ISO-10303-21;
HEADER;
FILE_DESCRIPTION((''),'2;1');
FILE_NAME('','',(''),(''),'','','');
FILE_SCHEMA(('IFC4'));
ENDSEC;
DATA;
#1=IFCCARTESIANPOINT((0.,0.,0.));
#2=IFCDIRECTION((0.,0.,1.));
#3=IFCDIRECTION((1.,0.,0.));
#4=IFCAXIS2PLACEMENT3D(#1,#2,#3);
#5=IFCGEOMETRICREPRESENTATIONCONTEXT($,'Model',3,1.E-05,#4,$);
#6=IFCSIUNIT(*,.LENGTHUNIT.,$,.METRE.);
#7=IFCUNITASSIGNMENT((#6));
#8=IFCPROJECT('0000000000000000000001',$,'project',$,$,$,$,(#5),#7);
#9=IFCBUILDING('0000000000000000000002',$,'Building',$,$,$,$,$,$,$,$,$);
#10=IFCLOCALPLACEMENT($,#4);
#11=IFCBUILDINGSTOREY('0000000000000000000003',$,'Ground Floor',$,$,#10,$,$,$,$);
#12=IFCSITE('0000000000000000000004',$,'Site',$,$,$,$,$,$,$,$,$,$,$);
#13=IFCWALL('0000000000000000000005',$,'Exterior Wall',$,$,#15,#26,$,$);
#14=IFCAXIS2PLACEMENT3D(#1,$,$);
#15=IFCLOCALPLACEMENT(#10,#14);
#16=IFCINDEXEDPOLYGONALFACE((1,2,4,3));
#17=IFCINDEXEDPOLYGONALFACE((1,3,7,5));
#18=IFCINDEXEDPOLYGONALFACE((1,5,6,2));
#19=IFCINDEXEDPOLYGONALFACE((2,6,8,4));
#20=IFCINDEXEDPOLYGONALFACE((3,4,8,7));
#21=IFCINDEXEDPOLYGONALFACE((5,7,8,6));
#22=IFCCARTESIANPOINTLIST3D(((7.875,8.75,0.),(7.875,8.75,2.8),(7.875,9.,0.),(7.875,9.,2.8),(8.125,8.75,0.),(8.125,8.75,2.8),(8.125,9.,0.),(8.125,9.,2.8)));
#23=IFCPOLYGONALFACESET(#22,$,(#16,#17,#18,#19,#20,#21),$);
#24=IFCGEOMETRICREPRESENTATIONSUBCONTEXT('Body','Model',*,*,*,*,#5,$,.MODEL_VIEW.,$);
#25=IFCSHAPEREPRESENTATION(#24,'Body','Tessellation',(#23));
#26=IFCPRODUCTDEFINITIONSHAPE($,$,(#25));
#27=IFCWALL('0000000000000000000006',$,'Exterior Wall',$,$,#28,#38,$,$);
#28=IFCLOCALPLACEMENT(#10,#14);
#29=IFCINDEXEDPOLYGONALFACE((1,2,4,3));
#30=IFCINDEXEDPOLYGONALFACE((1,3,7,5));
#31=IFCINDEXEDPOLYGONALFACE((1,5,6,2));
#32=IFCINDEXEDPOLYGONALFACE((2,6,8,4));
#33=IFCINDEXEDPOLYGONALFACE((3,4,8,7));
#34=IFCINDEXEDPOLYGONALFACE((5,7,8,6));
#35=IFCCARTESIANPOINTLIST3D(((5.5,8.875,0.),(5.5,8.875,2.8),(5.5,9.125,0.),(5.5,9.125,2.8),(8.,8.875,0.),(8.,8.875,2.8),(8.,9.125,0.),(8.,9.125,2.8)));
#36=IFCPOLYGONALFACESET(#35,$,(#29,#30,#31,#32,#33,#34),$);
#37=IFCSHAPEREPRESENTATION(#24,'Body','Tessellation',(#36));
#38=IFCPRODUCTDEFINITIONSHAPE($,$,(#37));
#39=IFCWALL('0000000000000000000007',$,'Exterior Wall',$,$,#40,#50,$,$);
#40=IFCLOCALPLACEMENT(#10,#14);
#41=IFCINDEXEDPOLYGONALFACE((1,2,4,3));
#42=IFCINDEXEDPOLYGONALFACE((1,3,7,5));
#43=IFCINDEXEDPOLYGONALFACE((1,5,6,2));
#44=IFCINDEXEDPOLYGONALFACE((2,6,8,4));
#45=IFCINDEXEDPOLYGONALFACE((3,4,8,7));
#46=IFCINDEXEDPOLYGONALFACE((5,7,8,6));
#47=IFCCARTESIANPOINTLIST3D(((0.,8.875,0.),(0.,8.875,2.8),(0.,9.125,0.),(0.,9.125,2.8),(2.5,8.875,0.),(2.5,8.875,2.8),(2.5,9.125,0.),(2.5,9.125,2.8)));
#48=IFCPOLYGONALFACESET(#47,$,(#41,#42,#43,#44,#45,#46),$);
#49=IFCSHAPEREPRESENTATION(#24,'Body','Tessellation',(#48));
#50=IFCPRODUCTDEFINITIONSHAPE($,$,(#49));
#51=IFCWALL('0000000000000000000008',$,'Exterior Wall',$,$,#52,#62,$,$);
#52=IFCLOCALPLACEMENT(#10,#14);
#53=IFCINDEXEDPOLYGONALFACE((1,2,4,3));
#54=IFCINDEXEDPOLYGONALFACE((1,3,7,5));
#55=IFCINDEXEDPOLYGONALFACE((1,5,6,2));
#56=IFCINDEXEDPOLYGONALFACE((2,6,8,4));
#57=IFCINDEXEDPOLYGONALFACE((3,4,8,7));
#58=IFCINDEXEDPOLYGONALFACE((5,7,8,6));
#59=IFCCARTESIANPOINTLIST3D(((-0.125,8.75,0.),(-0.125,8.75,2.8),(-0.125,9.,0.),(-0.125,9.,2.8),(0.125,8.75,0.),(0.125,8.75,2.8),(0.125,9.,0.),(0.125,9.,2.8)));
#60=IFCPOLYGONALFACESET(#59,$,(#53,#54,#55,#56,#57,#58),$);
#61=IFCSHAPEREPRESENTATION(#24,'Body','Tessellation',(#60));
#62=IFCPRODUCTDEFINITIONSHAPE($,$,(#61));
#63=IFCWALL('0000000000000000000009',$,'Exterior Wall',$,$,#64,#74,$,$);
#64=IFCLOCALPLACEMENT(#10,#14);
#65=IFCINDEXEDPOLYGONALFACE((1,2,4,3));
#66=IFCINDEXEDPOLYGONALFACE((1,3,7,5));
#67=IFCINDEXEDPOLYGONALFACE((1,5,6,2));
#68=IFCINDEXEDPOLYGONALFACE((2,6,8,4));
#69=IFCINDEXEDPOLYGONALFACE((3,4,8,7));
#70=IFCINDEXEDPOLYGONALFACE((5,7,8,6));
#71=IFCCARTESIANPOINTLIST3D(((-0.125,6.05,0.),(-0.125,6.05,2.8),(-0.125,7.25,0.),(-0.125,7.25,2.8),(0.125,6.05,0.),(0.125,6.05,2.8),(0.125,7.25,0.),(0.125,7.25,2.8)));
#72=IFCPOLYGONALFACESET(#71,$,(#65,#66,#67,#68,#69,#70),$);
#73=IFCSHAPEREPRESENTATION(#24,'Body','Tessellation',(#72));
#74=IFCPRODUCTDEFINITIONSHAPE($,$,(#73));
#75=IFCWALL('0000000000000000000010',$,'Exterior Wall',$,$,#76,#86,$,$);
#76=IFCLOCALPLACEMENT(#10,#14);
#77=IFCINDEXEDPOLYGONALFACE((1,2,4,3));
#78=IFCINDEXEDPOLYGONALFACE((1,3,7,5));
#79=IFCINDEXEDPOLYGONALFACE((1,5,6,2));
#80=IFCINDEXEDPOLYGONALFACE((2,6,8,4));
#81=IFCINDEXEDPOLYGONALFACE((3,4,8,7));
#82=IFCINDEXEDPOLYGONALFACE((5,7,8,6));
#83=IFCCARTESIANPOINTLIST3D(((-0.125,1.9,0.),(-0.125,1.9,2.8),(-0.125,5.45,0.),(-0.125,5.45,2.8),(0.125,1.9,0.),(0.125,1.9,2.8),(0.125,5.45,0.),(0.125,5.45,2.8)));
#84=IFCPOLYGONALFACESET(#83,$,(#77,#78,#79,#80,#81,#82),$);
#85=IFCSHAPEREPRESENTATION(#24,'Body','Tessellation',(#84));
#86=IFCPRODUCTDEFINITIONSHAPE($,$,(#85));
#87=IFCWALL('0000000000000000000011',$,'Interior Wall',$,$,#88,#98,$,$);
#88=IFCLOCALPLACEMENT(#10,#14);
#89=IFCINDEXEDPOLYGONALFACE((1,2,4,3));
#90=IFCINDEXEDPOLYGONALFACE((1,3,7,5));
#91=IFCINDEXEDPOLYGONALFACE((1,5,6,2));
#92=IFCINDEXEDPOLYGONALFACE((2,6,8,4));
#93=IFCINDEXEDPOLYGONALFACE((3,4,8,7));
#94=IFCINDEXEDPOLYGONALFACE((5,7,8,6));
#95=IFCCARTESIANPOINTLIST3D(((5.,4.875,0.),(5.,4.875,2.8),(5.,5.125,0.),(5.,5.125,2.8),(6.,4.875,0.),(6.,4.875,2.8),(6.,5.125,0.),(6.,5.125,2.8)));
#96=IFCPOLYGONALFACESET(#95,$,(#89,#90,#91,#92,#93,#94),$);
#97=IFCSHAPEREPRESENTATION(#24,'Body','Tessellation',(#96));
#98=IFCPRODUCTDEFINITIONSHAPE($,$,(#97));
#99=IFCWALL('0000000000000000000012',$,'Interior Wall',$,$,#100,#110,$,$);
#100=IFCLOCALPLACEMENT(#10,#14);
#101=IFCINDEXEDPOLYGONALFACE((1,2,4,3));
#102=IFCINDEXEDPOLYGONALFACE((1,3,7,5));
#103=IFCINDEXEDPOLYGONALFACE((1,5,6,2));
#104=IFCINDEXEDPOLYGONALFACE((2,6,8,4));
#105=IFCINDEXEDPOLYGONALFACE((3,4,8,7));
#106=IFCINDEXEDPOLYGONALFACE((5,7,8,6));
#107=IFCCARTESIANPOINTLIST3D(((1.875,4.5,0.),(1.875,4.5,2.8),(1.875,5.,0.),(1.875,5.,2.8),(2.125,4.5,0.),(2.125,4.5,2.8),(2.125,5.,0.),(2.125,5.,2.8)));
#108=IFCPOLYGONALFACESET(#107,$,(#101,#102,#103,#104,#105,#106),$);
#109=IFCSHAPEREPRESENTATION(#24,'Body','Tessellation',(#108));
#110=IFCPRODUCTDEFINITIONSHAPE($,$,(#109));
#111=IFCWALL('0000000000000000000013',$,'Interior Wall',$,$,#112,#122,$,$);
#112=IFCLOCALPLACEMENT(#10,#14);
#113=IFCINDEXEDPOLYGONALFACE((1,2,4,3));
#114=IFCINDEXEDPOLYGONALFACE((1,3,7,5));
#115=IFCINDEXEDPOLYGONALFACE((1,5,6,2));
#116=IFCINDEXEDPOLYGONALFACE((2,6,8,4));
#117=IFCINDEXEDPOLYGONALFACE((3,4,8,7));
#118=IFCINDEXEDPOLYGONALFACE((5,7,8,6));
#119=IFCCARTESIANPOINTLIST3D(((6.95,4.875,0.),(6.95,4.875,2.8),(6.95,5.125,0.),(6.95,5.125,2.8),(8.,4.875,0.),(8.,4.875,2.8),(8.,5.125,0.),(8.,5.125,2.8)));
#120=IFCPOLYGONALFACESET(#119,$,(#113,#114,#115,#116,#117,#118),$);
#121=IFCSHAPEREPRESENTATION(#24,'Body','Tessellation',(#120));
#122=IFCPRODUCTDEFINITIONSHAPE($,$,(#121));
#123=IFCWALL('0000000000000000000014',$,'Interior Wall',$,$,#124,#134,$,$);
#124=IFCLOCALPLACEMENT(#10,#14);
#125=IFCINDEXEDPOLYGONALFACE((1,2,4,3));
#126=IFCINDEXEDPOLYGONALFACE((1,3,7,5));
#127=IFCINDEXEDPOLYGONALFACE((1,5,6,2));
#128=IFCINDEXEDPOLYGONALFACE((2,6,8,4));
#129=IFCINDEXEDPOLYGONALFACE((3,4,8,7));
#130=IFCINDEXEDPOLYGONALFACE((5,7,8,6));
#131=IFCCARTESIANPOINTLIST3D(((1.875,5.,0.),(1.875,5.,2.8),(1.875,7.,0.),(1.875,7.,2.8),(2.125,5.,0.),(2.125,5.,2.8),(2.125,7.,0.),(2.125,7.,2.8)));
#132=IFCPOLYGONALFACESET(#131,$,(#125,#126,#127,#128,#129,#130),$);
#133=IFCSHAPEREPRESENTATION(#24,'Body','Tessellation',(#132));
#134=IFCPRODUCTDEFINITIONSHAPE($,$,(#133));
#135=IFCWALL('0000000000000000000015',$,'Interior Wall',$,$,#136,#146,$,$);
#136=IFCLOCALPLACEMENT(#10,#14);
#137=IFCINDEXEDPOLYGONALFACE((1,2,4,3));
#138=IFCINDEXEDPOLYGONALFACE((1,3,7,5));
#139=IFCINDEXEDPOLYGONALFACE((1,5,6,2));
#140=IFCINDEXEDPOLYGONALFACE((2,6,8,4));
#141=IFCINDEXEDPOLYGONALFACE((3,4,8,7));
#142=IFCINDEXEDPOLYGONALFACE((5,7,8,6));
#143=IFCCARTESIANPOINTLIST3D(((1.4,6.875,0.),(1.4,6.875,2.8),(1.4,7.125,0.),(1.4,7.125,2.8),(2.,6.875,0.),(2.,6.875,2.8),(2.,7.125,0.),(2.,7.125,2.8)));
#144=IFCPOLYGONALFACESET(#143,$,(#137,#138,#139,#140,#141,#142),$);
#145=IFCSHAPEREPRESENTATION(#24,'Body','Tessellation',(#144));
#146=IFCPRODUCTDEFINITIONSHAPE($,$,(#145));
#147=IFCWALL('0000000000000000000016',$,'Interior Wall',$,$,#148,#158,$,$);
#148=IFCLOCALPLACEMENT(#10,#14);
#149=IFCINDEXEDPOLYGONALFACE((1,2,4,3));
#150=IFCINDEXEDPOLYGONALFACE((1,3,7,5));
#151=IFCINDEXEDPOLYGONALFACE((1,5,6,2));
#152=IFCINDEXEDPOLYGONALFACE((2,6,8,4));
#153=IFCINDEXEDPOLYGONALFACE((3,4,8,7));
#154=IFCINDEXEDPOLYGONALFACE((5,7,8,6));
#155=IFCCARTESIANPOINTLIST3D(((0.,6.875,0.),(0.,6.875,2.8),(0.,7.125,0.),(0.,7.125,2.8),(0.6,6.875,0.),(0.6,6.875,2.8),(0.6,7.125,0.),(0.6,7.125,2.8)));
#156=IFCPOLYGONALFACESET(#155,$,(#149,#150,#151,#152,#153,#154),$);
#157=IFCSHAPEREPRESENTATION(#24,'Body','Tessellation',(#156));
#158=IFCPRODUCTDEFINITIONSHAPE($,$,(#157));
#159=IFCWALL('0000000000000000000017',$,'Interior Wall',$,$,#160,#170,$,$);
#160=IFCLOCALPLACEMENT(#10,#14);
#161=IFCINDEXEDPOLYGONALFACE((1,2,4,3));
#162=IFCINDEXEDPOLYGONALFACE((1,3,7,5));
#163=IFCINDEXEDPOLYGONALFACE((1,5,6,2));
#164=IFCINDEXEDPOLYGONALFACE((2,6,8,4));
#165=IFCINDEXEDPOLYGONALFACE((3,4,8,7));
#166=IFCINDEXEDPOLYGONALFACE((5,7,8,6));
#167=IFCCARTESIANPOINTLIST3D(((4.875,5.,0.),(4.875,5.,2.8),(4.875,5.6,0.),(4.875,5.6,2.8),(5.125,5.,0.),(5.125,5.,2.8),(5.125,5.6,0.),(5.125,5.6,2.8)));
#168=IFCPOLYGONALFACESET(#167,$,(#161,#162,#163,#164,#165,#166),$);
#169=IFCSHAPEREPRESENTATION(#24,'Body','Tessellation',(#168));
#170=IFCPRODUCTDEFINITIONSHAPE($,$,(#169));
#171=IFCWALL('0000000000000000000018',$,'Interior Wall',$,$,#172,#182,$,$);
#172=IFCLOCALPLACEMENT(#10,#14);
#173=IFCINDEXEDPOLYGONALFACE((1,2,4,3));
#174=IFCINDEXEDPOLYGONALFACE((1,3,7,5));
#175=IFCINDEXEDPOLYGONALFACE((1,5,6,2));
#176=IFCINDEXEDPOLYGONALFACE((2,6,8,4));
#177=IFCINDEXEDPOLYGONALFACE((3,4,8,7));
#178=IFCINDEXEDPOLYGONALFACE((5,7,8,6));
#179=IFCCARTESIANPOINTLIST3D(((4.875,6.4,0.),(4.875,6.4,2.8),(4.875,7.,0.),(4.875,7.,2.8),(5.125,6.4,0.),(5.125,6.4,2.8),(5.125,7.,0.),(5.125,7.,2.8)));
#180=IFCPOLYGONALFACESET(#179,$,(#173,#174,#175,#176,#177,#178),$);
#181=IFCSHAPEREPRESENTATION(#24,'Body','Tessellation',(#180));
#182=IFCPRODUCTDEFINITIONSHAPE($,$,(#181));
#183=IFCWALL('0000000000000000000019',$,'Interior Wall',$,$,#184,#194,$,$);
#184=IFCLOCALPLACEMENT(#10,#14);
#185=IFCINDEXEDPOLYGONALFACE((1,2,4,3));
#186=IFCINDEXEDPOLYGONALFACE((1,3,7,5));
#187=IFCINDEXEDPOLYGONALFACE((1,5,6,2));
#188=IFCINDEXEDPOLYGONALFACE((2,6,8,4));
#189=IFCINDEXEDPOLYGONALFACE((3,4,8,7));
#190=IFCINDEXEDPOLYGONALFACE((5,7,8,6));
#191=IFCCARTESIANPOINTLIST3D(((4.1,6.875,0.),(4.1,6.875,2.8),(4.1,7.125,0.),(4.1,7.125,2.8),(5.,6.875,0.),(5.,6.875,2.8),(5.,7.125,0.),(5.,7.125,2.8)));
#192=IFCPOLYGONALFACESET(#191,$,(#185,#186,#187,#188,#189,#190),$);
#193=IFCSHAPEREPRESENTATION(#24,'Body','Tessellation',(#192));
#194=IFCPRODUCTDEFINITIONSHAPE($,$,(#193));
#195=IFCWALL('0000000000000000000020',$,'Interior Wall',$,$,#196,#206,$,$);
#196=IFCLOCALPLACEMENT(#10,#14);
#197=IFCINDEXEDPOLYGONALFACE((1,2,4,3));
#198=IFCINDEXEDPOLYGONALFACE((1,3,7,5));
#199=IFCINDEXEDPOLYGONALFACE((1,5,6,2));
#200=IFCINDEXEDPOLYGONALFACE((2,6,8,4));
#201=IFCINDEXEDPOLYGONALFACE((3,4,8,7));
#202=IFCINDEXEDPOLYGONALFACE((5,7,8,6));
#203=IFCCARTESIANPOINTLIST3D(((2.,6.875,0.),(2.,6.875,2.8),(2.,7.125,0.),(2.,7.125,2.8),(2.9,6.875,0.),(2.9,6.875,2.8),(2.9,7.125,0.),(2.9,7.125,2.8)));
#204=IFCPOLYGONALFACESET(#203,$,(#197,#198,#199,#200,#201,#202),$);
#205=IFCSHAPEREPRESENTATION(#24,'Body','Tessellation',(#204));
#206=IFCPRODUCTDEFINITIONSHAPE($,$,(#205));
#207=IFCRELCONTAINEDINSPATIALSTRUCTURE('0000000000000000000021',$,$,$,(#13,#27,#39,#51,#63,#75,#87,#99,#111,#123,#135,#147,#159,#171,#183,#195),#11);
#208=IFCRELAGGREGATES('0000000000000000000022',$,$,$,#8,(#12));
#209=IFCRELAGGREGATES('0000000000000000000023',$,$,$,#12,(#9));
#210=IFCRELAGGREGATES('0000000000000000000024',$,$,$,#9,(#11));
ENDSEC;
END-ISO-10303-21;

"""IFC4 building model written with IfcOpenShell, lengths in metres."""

from ifc_helpers import new_model, si_unit, frame, origin_with_axes, place, context, subcontext, project, spatial, indexed_curve, outline, extrude, element, save


model = new_model("IFC4")

# Units and contexts
model_context = context("Model", 3, precision=1e-05, world=origin_with_axes())
body_context = subcontext(model_context, "Body", "Model", "MODEL_VIEW")
ifc_project = project(units=[si_unit("LENGTHUNIT", "METRE")], contexts=[model_context])

# Site, building, storey
site = spatial("IfcSite", under=ifc_project, Name="Site")
building = spatial("IfcBuilding", under=site, Name="Building")
storey_placement = place(None, origin_with_axes())
storey = spatial("IfcBuildingStorey", under=building, at=storey_placement, Name="Ground Floor")

# Walls
wall_1_placement = place(storey_placement, frame((8.0, 8.75, 0.0), z_axis=(0.0, 0.0, 1.0), x_axis=(0.0, 1.0, 0.0)))
element("IfcWall", 1, at=wall_1_placement, inside=storey, Name="Exterior Wall", context=body_context, shape_type="SweptSolid", body=[
    extrude(outline(indexed_curve([(0.0, 0.0), (0.0, 0.25), (0.25, 0.25), (0.25, 0.0), (0.0, 0.0)], self_intersect=False)), frame((0.0, -0.125, 0.0), z_axis=(0.0, 0.0, 1.0), x_axis=(1.0, 0.0, 0.0)), (0.0, 0.0, 1.0), 2.8),
])
for number, where, z_axis, x_axis, name in (
    (2, (8.0, 9.0, 0.0), (0.0, 0.0, 1.0), (-1.0, 0.0, 0.0), "Exterior Wall"),
    (3, (2.5, 9.0, 0.0), (0.0, 0.0, 1.0), (-1.0, 0.0, 0.0), "Exterior Wall"),
):
    element("IfcWall", number, at=place(storey_placement, frame(where, z_axis=z_axis, x_axis=x_axis)), inside=storey, Name=name, context=body_context, shape_type="SweptSolid", body=[
        extrude(outline(indexed_curve([(0.0, 0.0), (0.0, 0.25), (2.5, 0.25), (2.5, 0.0), (0.0, 0.0)], self_intersect=False)), frame((0.0, -0.125, 0.0), z_axis=(0.0, 0.0, 1.0), x_axis=(1.0, 0.0, 0.0)), (0.0, 0.0, 1.0), 2.8),
    ])
wall_2_placement = place(storey_placement, frame((0.0, 9.0, 0.0), z_axis=(0.0, 0.0, 1.0), x_axis=(0.0, -1.0, 0.0)))
element("IfcWall", 4, at=wall_2_placement, inside=storey, Name="Exterior Wall", context=body_context, shape_type="SweptSolid", body=[
    extrude(outline(indexed_curve([(0.0, 0.0), (0.0, 0.25), (0.25, 0.25), (0.25, 0.0), (0.0, 0.0)], self_intersect=False)), frame((0.0, -0.125, 0.0), z_axis=(0.0, 0.0, 1.0), x_axis=(1.0, 0.0, 0.0)), (0.0, 0.0, 1.0), 2.8),
])
wall_3_placement = place(storey_placement, frame((0.0, 7.25, 0.0), z_axis=(0.0, 0.0, 1.0), x_axis=(0.0, -1.0, 0.0)))
element("IfcWall", 5, at=wall_3_placement, inside=storey, Name="Exterior Wall", context=body_context, shape_type="SweptSolid", body=[
    extrude(outline(indexed_curve([(0.0, 0.0), (0.0, 0.25), (1.2, 0.25), (1.2, 0.0), (0.0, 0.0)], self_intersect=False)), frame((0.0, -0.125, 0.0), z_axis=(0.0, 0.0, 1.0), x_axis=(1.0, 0.0, 0.0)), (0.0, 0.0, 1.0), 2.8),
])
wall_4_placement = place(storey_placement, frame((0.0, 5.45, 0.0), z_axis=(0.0, 0.0, 1.0), x_axis=(0.0, -1.0, 0.0)))
element("IfcWall", 6, at=wall_4_placement, inside=storey, Name="Exterior Wall", context=body_context, shape_type="SweptSolid", body=[
    extrude(outline(indexed_curve([(0.0, 0.0), (0.0, 0.25), (3.55, 0.25), (3.55, 0.0), (0.0, 0.0)], self_intersect=False)), frame((0.0, -0.125, 0.0), z_axis=(0.0, 0.0, 1.0), x_axis=(1.0, 0.0, 0.0)), (0.0, 0.0, 1.0), 2.8),
])
wall_5_placement = place(storey_placement, frame((6.0, 5.0, 0.0), z_axis=(0.0, 0.0, 1.0), x_axis=(-1.0, 0.0, 0.0)))
element("IfcWall", 7, at=wall_5_placement, inside=storey, Name="Interior Wall", context=body_context, shape_type="SweptSolid", body=[
    extrude(outline(indexed_curve([(0.0, 0.0), (0.0, 0.25), (1.0, 0.25), (1.0, 0.0), (0.0, 0.0)], self_intersect=False)), frame((0.0, -0.125, 0.0), z_axis=(0.0, 0.0, 1.0), x_axis=(1.0, 0.0, 0.0)), (0.0, 0.0, 1.0), 2.8),
])
wall_6_placement = place(storey_placement, frame((2.0, 5.0, 0.0), z_axis=(0.0, 0.0, 1.0), x_axis=(0.0, -1.0, 0.0)))
element("IfcWall", 8, at=wall_6_placement, inside=storey, Name="Interior Wall", context=body_context, shape_type="SweptSolid", body=[
    extrude(outline(indexed_curve([(0.0, 0.0), (0.0, 0.25), (0.5, 0.25), (0.5, 0.0), (0.0, 0.0)], self_intersect=False)), frame((0.0, -0.125, 0.0), z_axis=(0.0, 0.0, 1.0), x_axis=(1.0, 0.0, 0.0)), (0.0, 0.0, 1.0), 2.8),
])
wall_7_placement = place(storey_placement, frame((8.0, 5.0, 0.0), z_axis=(0.0, 0.0, 1.0), x_axis=(-1.0, 0.0, 0.0)))
element("IfcWall", 9, at=wall_7_placement, inside=storey, Name="Interior Wall", context=body_context, shape_type="SweptSolid", body=[
    extrude(outline(indexed_curve([(0.0, 0.0), (0.0, 0.25), (1.05, 0.25), (1.05, 0.0), (0.0, 0.0)], self_intersect=False)), frame((0.0, -0.125, 0.0), z_axis=(0.0, 0.0, 1.0), x_axis=(1.0, 0.0, 0.0)), (0.0, 0.0, 1.0), 2.8),
])
wall_8_placement = place(storey_placement, frame((2.0, 5.0, 0.0), z_axis=(0.0, 0.0, 1.0), x_axis=(0.0, 1.0, 0.0)))
element("IfcWall", 10, at=wall_8_placement, inside=storey, Name="Interior Wall", context=body_context, shape_type="SweptSolid", body=[
    extrude(outline(indexed_curve([(0.0, 0.0), (0.0, 0.25), (2.0, 0.25), (2.0, 0.0), (0.0, 0.0)], self_intersect=False)), frame((0.0, -0.125, 0.0), z_axis=(0.0, 0.0, 1.0), x_axis=(1.0, 0.0, 0.0)), (0.0, 0.0, 1.0), 2.8),
])
for number, where, z_axis, x_axis, name in (
    (11, (2.0, 7.0, 0.0), (0.0, 0.0, 1.0), (-1.0, 0.0, 0.0), "Interior Wall"),
    (12, (0.6, 7.0, 0.0), (0.0, 0.0, 1.0), (-1.0, 0.0, 0.0), "Interior Wall"),
):
    element("IfcWall", number, at=place(storey_placement, frame(where, z_axis=z_axis, x_axis=x_axis)), inside=storey, Name=name, context=body_context, shape_type="SweptSolid", body=[
        extrude(outline(indexed_curve([(0.0, 0.0), (0.0, 0.25), (0.6, 0.25), (0.6, 0.0), (0.0, 0.0)], self_intersect=False)), frame((0.0, -0.125, 0.0), z_axis=(0.0, 0.0, 1.0), x_axis=(1.0, 0.0, 0.0)), (0.0, 0.0, 1.0), 2.8),
    ])
for number, where, z_axis, x_axis, name in (
    (13, (5.0, 5.0, 0.0), (0.0, 0.0, 1.0), (0.0, 1.0, 0.0), "Interior Wall"),
    (14, (5.0, 6.4, 0.0), (0.0, 0.0, 1.0), (0.0, 1.0, 0.0), "Interior Wall"),
):
    element("IfcWall", number, at=place(storey_placement, frame(where, z_axis=z_axis, x_axis=x_axis)), inside=storey, Name=name, context=body_context, shape_type="SweptSolid", body=[
        extrude(outline(indexed_curve([(0.0, 0.0), (0.0, 0.25), (0.6, 0.25), (0.6, 0.0), (0.0, 0.0)], self_intersect=False)), frame((0.0, -0.125, 0.0), z_axis=(0.0, 0.0, 1.0), x_axis=(1.0, 0.0, 0.0)), (0.0, 0.0, 1.0), 2.8),
    ])
wall_9_placement = place(storey_placement, frame((5.0, 7.0, 0.0), z_axis=(0.0, 0.0, 1.0), x_axis=(-1.0, 0.0, 0.0)))
element("IfcWall", 15, at=wall_9_placement, inside=storey, Name="Interior Wall", context=body_context, shape_type="SweptSolid", body=[
    extrude(outline(indexed_curve([(0.0, 0.0), (0.0, 0.25), (0.9, 0.25), (0.9, 0.0), (0.0, 0.0)], self_intersect=False)), frame((0.0, -0.125, 0.0), z_axis=(0.0, 0.0, 1.0), x_axis=(1.0, 0.0, 0.0)), (0.0, 0.0, 1.0), 2.8),
])
wall_10_placement = place(storey_placement, frame((2.9, 7.0, 0.0), z_axis=(0.0, 0.0, 1.0), x_axis=(-1.0, 0.0, 0.0)))
element("IfcWall", 16, at=wall_10_placement, inside=storey, Name="Interior Wall", context=body_context, shape_type="SweptSolid", body=[
    extrude(outline(indexed_curve([(0.0, 0.0), (0.0, 0.25), (0.9, 0.25), (0.9, 0.0), (0.0, 0.0)], self_intersect=False)), frame((0.0, -0.125, 0.0), z_axis=(0.0, 0.0, 1.0), x_axis=(1.0, 0.0, 0.0)), (0.0, 0.0, 1.0), 2.8),
])

save(model, "model.ifc")
